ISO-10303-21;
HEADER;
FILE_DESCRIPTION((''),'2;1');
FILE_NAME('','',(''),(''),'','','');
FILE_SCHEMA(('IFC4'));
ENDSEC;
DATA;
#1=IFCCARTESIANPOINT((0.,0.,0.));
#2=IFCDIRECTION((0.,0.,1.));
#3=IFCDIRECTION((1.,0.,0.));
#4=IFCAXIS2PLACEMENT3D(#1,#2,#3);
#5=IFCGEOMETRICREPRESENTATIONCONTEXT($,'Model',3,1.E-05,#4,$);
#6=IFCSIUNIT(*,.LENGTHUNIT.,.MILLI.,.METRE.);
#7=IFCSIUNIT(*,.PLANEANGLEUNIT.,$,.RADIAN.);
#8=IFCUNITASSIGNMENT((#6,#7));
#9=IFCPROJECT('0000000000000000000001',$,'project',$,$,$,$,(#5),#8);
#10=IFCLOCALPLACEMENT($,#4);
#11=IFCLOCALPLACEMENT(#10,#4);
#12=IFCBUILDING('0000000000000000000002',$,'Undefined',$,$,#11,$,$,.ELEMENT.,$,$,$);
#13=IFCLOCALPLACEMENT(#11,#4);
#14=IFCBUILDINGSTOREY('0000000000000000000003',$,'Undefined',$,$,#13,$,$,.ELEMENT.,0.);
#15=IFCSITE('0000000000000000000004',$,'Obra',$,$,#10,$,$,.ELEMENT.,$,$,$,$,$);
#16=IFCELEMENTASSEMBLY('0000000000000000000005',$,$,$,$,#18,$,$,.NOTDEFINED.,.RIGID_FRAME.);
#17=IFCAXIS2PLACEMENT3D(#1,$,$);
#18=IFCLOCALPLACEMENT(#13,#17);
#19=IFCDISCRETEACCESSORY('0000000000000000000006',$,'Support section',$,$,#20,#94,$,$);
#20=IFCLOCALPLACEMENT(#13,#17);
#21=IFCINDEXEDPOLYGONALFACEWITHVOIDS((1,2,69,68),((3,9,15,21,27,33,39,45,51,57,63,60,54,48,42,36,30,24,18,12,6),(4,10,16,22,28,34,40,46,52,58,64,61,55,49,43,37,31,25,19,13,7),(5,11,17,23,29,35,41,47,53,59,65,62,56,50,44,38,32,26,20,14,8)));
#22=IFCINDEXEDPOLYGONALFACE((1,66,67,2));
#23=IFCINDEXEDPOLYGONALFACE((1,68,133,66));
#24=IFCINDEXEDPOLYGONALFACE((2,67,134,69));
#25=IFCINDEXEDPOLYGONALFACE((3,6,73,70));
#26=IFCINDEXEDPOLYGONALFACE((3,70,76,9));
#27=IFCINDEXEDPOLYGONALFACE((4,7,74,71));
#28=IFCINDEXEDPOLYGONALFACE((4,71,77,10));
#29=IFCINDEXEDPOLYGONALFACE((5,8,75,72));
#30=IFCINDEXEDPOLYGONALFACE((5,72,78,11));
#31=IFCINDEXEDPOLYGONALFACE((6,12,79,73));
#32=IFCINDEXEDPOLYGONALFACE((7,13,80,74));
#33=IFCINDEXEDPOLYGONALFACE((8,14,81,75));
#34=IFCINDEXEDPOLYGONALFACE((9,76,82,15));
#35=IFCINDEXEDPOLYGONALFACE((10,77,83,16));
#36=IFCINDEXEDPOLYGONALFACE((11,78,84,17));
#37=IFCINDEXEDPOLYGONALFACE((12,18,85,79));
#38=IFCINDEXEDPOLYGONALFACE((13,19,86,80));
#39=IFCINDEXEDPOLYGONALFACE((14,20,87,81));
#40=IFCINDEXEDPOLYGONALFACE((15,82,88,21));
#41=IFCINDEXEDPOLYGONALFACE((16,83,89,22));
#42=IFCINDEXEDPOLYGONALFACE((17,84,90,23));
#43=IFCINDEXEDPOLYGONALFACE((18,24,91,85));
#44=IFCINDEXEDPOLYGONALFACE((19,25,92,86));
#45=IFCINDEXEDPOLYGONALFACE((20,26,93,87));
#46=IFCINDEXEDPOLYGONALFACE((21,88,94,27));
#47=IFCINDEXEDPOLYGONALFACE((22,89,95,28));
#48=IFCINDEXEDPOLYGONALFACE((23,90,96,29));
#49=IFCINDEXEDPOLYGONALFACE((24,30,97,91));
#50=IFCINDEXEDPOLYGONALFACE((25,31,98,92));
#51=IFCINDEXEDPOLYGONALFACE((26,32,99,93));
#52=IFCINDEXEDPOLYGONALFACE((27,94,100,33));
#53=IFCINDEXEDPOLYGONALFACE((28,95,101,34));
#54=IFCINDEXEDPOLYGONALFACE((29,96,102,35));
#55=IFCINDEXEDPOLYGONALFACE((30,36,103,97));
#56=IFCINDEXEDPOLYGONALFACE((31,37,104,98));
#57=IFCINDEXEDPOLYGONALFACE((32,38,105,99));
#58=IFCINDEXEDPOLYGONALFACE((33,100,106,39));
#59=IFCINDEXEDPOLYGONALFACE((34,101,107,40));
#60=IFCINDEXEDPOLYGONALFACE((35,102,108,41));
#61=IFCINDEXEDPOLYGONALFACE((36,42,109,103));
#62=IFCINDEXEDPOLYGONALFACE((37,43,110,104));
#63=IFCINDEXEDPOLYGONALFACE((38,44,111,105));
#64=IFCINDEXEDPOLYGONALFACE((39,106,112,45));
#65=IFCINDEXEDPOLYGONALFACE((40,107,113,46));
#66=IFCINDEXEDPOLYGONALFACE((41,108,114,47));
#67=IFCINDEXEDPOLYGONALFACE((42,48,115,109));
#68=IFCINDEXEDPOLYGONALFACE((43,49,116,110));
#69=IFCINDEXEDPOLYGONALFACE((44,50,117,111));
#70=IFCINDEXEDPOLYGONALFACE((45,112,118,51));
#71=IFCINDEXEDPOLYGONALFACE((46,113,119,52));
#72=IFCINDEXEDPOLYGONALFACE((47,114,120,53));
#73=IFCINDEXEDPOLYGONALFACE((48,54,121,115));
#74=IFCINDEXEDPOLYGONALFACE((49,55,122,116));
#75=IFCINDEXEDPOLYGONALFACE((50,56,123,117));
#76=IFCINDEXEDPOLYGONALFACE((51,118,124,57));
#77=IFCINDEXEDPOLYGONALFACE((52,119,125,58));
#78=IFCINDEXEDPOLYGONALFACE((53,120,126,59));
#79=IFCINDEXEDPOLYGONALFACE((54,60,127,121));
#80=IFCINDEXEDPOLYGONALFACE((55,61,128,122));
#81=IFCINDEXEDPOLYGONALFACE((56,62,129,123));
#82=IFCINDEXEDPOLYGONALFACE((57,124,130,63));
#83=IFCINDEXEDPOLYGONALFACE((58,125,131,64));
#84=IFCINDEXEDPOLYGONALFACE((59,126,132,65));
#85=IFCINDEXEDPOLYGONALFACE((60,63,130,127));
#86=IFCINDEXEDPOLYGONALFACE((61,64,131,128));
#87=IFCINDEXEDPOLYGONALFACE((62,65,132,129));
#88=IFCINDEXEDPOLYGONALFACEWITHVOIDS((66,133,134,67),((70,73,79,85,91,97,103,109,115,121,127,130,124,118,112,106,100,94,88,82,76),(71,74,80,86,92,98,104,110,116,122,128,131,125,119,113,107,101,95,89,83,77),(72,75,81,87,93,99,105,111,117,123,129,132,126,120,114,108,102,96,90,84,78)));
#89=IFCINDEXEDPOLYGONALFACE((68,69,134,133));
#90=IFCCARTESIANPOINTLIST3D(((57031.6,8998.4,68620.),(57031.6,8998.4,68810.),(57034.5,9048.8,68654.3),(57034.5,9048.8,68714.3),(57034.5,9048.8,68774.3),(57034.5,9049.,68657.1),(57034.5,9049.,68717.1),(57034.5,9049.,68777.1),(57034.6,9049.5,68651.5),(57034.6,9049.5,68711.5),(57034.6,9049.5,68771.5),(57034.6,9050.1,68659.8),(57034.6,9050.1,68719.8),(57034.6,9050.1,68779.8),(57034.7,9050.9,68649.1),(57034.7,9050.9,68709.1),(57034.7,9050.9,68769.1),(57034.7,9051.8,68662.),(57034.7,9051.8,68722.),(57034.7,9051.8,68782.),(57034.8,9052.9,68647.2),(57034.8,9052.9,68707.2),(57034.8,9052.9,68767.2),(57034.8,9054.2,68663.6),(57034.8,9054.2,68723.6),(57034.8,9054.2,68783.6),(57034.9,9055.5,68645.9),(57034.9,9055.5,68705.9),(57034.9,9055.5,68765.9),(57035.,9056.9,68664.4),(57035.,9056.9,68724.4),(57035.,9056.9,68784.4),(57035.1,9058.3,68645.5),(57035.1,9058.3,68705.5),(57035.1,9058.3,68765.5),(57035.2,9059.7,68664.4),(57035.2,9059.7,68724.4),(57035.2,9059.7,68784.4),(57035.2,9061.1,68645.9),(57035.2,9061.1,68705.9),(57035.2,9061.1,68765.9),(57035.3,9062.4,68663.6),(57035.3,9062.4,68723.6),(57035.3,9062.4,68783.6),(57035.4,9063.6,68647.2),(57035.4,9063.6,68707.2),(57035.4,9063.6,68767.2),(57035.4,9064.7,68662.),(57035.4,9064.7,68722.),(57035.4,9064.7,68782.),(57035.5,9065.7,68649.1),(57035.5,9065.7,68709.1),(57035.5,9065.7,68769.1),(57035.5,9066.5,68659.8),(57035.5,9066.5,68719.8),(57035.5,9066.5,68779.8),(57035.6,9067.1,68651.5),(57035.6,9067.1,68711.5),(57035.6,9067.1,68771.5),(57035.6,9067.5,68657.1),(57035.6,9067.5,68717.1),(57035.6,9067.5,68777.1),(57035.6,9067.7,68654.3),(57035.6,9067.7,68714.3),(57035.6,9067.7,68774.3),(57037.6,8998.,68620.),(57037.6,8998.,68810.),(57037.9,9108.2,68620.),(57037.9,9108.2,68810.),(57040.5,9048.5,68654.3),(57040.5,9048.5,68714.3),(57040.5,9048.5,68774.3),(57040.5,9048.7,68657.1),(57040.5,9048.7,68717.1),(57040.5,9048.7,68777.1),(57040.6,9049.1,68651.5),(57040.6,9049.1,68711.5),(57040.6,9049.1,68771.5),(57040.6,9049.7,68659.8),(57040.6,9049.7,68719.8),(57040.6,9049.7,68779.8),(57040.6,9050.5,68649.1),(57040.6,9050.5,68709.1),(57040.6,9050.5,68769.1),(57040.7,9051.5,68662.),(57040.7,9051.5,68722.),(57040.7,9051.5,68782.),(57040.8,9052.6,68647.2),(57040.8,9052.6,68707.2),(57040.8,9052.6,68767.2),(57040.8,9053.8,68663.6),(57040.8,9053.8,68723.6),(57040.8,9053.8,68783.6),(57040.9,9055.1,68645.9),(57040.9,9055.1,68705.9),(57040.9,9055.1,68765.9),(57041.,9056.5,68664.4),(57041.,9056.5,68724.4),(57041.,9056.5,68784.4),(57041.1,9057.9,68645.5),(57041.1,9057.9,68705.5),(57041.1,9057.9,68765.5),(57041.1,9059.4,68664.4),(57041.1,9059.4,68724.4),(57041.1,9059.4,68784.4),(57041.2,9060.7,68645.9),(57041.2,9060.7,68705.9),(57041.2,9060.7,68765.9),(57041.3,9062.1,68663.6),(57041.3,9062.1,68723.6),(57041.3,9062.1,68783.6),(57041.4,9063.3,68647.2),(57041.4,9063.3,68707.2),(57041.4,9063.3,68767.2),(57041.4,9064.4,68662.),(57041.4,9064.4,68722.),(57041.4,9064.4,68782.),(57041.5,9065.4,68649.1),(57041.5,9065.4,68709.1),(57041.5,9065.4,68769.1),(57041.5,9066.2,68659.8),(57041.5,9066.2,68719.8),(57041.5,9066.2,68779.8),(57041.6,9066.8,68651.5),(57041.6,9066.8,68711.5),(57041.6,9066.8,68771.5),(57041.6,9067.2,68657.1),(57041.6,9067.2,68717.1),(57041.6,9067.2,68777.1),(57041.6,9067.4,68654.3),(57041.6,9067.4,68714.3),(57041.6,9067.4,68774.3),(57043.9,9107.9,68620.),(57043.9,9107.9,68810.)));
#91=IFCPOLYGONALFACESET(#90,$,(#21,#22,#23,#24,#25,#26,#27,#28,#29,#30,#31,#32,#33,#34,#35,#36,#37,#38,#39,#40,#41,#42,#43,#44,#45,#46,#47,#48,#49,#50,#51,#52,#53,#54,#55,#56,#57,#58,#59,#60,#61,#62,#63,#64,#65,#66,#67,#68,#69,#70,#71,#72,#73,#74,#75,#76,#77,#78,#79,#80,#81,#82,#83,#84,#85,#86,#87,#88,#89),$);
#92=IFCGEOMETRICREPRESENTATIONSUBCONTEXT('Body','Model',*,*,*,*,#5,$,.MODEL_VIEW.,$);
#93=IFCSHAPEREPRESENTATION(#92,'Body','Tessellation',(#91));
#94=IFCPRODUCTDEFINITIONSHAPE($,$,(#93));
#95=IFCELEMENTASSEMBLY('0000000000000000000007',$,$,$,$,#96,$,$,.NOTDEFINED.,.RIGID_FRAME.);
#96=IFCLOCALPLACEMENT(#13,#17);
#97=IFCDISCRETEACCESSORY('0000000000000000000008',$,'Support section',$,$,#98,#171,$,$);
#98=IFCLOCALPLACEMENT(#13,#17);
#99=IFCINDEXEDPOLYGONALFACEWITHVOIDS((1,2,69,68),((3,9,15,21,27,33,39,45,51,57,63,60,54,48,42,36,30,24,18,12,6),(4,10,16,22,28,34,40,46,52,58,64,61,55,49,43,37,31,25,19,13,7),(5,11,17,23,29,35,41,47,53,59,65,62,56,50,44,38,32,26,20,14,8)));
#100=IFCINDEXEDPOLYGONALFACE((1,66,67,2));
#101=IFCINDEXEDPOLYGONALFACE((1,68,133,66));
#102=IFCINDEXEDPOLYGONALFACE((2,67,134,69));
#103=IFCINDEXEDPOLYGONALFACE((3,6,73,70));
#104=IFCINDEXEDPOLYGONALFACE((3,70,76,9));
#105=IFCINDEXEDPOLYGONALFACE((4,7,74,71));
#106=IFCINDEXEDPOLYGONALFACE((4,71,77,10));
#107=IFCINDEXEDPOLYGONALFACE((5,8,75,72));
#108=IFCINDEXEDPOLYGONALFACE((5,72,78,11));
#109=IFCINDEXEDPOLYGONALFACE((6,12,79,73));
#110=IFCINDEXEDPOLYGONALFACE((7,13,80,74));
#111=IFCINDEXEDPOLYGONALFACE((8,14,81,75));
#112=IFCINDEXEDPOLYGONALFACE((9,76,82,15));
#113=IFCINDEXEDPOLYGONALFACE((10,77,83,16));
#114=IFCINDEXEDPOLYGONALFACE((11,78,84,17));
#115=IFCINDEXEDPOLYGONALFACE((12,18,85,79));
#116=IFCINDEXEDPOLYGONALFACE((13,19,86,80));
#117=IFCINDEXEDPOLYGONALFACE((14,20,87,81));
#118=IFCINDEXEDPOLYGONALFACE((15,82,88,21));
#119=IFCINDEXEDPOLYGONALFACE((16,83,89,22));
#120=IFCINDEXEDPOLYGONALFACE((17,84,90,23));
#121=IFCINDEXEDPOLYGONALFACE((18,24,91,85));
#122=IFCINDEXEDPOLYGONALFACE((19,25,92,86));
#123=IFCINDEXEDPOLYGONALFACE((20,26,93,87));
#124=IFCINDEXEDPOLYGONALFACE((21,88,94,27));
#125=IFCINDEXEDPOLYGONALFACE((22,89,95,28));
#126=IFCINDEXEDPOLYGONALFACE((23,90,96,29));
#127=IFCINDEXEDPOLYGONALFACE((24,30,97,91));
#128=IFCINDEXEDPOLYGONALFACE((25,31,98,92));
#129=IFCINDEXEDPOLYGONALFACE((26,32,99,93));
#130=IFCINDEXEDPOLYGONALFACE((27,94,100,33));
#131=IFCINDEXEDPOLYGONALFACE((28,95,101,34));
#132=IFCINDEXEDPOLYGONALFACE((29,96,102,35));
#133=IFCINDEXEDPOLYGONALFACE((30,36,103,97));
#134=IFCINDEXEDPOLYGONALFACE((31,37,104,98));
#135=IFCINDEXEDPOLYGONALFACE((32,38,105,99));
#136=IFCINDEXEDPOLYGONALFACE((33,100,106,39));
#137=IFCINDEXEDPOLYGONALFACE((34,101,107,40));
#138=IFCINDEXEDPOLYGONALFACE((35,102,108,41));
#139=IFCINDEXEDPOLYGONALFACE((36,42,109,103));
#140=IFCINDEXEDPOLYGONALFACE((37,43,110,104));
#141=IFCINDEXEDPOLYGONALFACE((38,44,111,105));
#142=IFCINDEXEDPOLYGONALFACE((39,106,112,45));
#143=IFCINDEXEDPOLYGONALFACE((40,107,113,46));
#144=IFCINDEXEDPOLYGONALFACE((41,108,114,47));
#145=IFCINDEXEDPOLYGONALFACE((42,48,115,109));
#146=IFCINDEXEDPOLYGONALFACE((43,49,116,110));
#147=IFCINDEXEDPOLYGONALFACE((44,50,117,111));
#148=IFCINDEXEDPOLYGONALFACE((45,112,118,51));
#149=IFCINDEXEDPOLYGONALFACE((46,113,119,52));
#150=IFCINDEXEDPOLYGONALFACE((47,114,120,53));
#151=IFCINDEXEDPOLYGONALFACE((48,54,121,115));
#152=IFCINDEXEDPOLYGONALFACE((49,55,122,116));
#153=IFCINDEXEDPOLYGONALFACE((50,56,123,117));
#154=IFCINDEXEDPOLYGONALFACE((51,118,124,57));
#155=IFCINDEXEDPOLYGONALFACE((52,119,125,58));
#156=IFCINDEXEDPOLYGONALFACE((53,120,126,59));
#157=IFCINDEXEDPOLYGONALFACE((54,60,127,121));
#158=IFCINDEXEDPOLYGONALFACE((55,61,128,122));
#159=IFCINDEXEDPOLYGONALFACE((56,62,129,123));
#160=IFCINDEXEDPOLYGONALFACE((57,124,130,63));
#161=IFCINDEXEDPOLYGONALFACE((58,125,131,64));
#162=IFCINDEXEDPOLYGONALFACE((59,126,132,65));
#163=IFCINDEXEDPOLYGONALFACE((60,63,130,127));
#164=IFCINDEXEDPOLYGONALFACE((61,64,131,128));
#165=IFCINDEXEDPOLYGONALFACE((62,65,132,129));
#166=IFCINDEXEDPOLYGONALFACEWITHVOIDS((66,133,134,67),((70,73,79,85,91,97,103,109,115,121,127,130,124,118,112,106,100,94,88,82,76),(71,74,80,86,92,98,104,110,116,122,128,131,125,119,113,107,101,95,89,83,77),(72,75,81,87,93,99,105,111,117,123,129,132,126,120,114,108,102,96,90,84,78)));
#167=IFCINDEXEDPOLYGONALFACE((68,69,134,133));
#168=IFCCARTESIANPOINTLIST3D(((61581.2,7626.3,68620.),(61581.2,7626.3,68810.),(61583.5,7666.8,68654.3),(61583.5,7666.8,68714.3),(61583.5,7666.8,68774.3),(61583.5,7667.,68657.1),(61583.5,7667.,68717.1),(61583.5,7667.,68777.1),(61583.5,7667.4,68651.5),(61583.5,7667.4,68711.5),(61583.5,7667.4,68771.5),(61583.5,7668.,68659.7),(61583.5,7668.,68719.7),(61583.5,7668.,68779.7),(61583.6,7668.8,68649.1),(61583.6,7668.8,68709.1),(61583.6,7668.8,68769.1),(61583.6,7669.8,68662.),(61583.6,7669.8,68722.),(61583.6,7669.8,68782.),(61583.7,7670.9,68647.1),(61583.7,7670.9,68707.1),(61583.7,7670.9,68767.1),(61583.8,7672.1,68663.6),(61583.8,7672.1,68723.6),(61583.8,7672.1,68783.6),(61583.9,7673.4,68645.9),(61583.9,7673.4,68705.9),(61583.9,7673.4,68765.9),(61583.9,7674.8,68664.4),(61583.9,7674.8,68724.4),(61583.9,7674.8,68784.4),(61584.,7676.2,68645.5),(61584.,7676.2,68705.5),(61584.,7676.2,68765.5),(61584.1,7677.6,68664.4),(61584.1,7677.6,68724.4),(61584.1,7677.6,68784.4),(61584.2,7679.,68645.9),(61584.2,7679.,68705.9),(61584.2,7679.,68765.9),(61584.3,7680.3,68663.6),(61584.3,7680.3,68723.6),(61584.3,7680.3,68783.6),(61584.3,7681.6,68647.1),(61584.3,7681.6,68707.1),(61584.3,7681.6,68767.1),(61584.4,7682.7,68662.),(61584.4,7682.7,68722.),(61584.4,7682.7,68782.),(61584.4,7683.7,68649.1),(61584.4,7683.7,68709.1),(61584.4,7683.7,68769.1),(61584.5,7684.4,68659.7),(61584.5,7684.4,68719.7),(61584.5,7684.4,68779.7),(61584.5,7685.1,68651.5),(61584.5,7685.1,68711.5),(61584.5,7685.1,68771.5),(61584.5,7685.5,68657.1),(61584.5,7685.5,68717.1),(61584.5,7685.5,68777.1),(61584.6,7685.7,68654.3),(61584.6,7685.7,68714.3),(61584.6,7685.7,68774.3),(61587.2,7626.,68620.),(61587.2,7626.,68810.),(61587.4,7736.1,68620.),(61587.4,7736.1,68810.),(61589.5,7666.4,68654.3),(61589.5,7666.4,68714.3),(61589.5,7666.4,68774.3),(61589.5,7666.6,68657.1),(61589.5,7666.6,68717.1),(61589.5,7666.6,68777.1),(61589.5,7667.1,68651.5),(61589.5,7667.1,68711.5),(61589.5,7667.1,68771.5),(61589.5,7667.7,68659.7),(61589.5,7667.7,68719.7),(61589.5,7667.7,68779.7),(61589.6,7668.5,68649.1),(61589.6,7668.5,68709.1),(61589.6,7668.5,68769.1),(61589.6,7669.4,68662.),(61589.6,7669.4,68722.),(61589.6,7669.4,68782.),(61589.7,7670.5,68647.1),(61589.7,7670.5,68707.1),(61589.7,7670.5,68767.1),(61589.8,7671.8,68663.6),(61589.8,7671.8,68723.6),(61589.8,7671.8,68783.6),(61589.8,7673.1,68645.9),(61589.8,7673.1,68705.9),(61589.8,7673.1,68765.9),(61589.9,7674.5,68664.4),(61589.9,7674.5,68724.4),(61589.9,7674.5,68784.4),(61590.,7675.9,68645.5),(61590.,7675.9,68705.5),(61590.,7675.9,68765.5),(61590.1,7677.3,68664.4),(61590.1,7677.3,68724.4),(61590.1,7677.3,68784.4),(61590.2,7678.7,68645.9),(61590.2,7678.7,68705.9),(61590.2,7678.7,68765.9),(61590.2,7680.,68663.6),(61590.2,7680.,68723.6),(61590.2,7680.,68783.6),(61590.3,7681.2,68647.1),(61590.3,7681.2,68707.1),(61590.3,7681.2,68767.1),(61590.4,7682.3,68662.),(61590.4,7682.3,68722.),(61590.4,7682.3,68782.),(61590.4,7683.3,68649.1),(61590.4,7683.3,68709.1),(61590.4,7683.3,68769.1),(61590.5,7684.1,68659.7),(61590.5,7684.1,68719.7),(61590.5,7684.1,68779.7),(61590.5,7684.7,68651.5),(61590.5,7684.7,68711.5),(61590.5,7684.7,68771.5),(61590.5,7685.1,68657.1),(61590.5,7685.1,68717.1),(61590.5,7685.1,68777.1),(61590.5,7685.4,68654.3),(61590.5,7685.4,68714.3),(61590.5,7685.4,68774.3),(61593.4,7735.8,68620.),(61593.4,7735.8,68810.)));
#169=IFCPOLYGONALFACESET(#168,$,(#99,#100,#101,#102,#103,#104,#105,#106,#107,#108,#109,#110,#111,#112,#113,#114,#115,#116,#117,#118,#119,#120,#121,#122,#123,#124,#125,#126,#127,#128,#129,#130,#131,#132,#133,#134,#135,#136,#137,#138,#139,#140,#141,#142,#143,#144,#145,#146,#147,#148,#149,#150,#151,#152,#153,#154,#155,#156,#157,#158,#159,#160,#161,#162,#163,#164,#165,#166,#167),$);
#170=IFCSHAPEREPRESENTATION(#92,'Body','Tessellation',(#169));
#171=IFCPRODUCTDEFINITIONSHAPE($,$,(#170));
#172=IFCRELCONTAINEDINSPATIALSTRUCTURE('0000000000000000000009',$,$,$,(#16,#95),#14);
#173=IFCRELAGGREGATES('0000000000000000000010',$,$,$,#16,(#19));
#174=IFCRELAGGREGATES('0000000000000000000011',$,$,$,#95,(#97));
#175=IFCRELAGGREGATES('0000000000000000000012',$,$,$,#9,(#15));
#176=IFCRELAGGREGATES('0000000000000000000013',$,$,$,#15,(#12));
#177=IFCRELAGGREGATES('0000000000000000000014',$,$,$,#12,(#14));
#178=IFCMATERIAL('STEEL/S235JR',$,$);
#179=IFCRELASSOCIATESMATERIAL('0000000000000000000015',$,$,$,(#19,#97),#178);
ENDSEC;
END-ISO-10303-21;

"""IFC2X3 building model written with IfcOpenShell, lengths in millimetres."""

from ifc_helpers import new_model, si_unit, frame, origin_with_axes, origin_2d_with_axis, place, context, subcontext, project, spatial, rectangle, circle, extrude, source, transform, mapped, material, element, aggregate, save


model = new_model("IFC2X3")

# Units and contexts
model_context = context("Model", 3, precision=1e-05, world=origin_with_axes())
body_context = subcontext(model_context, "Body", "Model", "MODEL_VIEW")
ifc_project = project(units=[si_unit("LENGTHUNIT", "METRE", prefix="MILLI"), si_unit("PLANEANGLEUNIT", "RADIAN")], contexts=[model_context])

# Site, building, storey
site_placement = place(None, origin_with_axes())
site = spatial("IfcSite", under=ifc_project, at=site_placement, Name="Obra", CompositionType="ELEMENT")
building_placement = place(site_placement, origin_with_axes())
building = spatial("IfcBuilding", under=site, at=building_placement, Name="Undefined", CompositionType="ELEMENT")
storey_placement = place(building_placement, origin_with_axes())
storey = spatial("IfcBuildingStorey", under=building, at=storey_placement, Name="Undefined", CompositionType="ELEMENT", Elevation=0.0)

# Element assembly
assembly_1_placement = place(storey_placement, origin_with_axes())
assembly_1 = element("IfcElementAssembly", 1, at=assembly_1_placement, inside=storey, AssemblyPlace="NOTDEFINED", PredefinedType="RIGID_FRAME")
ifc_material_1 = material(Name="STEEL/S235JR")

# Discrete accessory, opening
discrete_accessory_1_placement = place(assembly_1_placement, frame((57037.8, 9053.1, 68620.0), z_axis=(0.0, 0.0, 1.0), x_axis=(-0.05711, -0.998368, 0.0)))
discrete_accessory_1 = element("IfcDiscreteAccessory", 2, at=discrete_accessory_1_placement, material=ifc_material_1, Name="Support section", context=body_context, shape_type="SweptSolid", body=[
    extrude(rectangle(XDim=6.0, YDim=110.0, at=origin_2d_with_axis()), frame((0.0, 0.0, 190.0), z_axis=(0.0, 0.0, -1.0), x_axis=(0.0, 1.0, 0.0)), (0.0, 0.0, 1.0), 190.0),
])
shared_shape_1 = source(origin_with_axes(), body_context, "Body", "SweptSolid", [
    extrude(circle(Radius=9.5, at=origin_2d_with_axis()), frame((0.0, -9.2, 0.0), z_axis=(0.0, 1.0, 0.0), x_axis=(1.0, 0.0, 0.0)), (0.0, 0.0, 1.0), 6.2),
])
opening_1_placement = place(assembly_1_placement, frame((57029.1, 9008.5, 68835.0), z_axis=(0.05711, 0.998368, 0.0), x_axis=(0.0, 0.0, -1.0)))
element("IfcOpeningElement", 3, at=opening_1_placement, cuts=discrete_accessory_1, ObjectType="Opening", context=body_context, shape_type="MappedRepresentation", body=[
    mapped(shared_shape_1, transform((60.0, 0.0, 50.0))),
    mapped(shared_shape_1, transform((120.0, 0.0, 50.0))),
    mapped(shared_shape_1, transform((180.0, 0.0, 50.0))),
])
aggregate(assembly_1, [discrete_accessory_1])

# Element assembly, discrete accessory, opening
assembly_2_placement = place(storey_placement, origin_with_axes())
assembly_2 = element("IfcElementAssembly", 4, at=assembly_2_placement, inside=storey, AssemblyPlace="NOTDEFINED", PredefinedType="RIGID_FRAME")
discrete_accessory_2_placement = place(assembly_2_placement, frame((61587.3, 7681.1, 68620.0), z_axis=(0.0, 0.0, 1.0), x_axis=(0.05711, 0.998368, 0.0)))
discrete_accessory_2 = element("IfcDiscreteAccessory", 5, at=discrete_accessory_2_placement, material=ifc_material_1, Name="Support section", context=body_context, shape_type="SweptSolid", body=[
    extrude(rectangle(XDim=6.0, YDim=110.0, at=origin_2d_with_axis()), frame((0.0, 0.0, 190.0), z_axis=(0.0, 0.0, -1.0), x_axis=(0.0, 1.0, 0.0)), (0.0, 0.0, 1.0), 190.0),
])
opening_2_placement = place(assembly_2_placement, frame((61596.0, 7725.6, 68835.0), z_axis=(-0.05711, -0.998368, 0.0), x_axis=(0.0, 0.0, -1.0)))
element("IfcOpeningElement", 6, at=opening_2_placement, cuts=discrete_accessory_2, ObjectType="Opening", context=body_context, shape_type="MappedRepresentation", body=[
    mapped(shared_shape_1, transform((60.0, 0.0, 50.0))),
    mapped(shared_shape_1, transform((120.0, 0.0, 50.0))),
    mapped(shared_shape_1, transform((180.0, 0.0, 50.0))),
])
aggregate(assembly_2, [discrete_accessory_2])

save(model, "model.ifc")
